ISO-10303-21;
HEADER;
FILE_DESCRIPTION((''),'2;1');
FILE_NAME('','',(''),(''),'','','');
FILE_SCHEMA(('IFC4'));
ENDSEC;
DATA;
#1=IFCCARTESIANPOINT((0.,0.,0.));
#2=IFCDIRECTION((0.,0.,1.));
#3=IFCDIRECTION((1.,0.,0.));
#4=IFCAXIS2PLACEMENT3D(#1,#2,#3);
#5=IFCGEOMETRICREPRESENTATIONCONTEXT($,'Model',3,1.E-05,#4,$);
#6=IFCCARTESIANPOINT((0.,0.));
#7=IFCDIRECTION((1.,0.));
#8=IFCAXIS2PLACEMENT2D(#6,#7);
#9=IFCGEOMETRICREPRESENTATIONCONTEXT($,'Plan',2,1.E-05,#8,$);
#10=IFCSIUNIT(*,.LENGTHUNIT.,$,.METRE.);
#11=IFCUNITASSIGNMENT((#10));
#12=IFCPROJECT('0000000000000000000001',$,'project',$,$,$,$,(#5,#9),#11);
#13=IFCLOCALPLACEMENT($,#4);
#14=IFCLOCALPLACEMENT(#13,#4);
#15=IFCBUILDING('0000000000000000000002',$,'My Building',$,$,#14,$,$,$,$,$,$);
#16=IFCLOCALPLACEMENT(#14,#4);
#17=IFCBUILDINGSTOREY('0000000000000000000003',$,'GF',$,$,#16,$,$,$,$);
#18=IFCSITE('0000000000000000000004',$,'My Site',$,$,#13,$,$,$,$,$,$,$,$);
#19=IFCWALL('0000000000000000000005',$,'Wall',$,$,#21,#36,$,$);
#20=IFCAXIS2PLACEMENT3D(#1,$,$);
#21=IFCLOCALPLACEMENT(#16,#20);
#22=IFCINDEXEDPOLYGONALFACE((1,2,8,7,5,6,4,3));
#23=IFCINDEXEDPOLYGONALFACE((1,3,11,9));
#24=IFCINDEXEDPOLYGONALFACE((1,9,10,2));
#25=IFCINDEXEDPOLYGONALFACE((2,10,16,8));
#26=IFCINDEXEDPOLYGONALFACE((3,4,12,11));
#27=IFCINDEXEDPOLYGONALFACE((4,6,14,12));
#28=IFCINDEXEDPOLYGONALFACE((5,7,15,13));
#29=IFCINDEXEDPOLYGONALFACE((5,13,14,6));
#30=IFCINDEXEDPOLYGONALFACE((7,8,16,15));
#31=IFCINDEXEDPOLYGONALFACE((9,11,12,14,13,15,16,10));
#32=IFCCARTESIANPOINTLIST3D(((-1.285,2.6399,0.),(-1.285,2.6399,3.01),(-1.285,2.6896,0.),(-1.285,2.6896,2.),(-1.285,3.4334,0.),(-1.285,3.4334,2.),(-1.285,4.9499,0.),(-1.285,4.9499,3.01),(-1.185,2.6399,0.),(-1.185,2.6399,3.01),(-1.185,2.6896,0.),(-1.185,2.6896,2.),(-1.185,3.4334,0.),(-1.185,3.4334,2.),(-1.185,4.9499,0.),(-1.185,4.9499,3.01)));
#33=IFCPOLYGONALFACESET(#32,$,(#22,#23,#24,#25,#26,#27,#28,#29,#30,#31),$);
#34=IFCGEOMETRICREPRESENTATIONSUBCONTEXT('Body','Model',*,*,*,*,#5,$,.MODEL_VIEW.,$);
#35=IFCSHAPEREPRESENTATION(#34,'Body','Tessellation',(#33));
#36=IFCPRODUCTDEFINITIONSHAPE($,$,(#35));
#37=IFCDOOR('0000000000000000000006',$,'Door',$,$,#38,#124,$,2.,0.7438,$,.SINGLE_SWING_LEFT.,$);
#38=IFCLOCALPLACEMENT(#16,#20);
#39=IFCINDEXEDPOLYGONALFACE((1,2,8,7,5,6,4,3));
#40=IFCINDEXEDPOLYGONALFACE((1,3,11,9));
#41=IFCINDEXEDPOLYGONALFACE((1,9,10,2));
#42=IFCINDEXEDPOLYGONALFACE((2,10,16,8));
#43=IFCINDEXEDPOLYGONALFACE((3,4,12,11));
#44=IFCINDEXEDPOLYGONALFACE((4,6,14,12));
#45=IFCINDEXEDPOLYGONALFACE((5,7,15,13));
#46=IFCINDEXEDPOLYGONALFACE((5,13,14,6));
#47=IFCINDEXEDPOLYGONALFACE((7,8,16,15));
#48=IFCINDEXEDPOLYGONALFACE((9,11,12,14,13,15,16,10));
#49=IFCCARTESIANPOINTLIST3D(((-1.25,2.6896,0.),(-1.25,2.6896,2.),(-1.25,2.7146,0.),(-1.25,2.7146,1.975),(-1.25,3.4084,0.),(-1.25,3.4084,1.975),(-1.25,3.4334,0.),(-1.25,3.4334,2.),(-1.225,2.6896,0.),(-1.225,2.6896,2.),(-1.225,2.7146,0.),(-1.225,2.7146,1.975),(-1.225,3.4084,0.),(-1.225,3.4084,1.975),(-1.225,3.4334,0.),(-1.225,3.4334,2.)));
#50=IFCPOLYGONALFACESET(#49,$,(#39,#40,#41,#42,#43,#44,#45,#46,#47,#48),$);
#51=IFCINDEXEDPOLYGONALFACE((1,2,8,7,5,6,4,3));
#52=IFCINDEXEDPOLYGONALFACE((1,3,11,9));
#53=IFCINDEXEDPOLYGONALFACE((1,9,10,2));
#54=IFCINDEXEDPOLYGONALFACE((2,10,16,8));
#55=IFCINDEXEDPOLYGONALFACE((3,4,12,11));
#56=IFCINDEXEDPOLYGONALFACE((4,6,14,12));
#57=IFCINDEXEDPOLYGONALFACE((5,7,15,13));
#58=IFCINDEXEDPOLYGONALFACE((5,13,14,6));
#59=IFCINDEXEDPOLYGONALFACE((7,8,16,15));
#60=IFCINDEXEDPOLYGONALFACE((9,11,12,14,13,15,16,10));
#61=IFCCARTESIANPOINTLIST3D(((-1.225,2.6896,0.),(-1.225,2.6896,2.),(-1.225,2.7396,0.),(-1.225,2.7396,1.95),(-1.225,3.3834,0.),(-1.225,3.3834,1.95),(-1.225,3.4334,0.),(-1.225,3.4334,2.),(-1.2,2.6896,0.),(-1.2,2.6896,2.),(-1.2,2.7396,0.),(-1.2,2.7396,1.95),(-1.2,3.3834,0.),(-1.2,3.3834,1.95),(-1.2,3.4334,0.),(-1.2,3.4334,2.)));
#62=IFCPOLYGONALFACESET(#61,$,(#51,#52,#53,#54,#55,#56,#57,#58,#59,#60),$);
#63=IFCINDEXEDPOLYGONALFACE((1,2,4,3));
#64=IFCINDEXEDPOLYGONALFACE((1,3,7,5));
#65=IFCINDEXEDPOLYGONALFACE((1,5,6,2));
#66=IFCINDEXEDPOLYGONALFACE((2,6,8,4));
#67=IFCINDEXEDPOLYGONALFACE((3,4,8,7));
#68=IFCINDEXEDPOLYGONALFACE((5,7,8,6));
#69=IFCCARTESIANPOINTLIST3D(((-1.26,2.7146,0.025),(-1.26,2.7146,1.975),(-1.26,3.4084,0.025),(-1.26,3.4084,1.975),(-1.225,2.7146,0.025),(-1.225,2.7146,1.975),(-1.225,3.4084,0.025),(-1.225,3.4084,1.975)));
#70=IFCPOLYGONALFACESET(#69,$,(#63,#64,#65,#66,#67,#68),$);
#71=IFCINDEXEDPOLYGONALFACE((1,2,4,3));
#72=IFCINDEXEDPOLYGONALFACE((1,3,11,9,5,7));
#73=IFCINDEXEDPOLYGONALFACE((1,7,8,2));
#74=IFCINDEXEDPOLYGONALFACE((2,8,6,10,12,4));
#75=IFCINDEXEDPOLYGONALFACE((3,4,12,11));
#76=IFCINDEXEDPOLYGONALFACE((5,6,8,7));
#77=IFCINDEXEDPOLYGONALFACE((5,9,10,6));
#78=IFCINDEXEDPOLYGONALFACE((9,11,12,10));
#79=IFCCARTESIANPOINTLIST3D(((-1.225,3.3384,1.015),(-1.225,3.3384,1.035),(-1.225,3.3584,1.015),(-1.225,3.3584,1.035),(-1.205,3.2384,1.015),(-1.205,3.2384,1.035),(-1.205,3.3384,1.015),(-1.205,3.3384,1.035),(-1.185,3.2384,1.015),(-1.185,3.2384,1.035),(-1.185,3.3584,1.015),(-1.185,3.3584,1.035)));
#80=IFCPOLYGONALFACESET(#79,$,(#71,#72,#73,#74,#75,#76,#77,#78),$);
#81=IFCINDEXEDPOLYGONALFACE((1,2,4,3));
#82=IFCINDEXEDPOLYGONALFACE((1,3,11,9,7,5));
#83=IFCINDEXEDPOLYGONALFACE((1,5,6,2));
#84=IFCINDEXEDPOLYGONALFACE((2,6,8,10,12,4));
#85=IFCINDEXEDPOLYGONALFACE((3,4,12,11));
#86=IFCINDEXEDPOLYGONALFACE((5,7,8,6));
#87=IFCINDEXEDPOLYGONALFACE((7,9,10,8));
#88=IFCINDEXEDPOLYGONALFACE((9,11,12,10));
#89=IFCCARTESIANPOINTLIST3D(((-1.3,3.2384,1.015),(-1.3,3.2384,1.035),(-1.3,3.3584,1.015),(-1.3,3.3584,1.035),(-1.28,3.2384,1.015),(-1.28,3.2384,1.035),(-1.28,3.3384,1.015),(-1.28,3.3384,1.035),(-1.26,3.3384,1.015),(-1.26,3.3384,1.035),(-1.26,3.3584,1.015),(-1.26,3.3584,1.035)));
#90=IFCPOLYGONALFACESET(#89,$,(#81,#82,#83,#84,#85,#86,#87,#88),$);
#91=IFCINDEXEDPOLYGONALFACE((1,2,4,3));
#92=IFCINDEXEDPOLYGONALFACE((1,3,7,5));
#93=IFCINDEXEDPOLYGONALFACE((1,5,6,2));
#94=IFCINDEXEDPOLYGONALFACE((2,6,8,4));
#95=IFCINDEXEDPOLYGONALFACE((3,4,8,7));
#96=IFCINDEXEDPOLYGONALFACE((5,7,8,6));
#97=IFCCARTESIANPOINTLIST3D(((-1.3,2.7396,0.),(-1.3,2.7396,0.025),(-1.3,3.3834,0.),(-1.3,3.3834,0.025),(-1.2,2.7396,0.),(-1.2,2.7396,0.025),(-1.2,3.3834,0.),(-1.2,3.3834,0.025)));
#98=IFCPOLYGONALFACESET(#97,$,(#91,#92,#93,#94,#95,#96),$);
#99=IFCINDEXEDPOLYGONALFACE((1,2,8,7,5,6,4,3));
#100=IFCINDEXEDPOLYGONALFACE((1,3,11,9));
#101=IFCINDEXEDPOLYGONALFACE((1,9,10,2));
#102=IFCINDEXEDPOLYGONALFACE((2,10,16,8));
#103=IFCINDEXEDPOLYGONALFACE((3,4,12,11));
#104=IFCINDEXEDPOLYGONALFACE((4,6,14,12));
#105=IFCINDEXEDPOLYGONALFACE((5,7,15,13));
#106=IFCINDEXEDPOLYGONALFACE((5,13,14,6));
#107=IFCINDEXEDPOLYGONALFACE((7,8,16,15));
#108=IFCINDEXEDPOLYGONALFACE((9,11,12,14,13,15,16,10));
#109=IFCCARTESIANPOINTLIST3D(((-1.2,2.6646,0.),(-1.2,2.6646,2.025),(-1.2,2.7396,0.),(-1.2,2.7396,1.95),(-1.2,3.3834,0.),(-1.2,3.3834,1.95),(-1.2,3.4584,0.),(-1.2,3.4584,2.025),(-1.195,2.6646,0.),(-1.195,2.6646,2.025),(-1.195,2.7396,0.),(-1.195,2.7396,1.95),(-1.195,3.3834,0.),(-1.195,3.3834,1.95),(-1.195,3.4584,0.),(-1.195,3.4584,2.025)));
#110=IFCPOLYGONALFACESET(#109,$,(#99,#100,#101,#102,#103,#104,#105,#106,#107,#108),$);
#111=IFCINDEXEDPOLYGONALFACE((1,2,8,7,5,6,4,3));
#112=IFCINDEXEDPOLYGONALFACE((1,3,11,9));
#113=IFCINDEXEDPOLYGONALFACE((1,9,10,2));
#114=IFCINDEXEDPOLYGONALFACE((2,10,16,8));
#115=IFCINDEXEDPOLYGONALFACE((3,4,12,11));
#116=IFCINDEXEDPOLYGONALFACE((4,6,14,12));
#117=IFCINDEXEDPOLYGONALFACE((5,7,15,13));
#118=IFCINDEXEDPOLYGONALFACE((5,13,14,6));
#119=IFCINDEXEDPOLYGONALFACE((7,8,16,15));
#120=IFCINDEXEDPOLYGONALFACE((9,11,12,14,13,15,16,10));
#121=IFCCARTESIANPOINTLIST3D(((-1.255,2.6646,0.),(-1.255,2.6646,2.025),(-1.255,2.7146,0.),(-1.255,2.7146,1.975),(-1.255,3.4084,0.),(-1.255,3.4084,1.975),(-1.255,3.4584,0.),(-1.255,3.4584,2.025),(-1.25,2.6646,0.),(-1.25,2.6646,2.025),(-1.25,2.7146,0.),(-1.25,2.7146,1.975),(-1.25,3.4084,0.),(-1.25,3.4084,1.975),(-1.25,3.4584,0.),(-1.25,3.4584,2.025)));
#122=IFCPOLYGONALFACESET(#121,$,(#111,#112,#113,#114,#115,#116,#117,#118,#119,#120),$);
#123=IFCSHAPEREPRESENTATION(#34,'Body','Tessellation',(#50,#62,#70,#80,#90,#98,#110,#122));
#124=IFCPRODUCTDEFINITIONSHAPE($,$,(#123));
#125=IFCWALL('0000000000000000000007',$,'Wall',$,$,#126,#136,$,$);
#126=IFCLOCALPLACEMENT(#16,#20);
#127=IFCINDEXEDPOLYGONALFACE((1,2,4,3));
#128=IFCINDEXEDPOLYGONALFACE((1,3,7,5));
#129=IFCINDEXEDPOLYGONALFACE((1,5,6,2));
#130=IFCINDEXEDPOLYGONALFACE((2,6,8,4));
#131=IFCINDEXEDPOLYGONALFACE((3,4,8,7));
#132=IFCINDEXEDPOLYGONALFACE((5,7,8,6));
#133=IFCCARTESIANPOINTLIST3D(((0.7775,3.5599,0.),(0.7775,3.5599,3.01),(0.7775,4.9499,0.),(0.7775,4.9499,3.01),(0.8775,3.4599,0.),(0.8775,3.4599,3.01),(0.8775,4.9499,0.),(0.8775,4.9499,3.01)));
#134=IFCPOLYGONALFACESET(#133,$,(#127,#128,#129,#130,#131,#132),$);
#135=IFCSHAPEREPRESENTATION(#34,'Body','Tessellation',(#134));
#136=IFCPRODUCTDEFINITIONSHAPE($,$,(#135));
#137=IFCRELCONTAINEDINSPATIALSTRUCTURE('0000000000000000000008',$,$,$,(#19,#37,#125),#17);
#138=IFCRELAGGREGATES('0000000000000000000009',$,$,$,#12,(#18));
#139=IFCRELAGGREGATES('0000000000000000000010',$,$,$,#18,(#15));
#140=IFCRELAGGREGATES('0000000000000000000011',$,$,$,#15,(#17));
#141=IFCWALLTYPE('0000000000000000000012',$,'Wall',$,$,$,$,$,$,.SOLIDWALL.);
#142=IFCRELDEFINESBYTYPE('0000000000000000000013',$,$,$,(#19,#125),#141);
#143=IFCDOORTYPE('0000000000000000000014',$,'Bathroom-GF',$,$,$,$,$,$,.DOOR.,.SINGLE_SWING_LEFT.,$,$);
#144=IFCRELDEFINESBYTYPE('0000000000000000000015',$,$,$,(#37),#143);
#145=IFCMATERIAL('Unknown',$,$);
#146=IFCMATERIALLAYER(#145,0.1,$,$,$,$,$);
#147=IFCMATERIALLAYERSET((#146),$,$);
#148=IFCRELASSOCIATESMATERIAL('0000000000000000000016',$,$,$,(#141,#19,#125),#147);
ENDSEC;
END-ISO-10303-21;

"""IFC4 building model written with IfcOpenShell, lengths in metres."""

from ifc_helpers import new_model, entity, si_unit, frame, origin_with_axes, origin_2d_with_axis, place, context, subcontext, project, spatial, line, indexed_curve, outline, extrude, shape, source, transform, mapped, material, layer, layer_set, layer_usage, type_object, type_shapes, element, fill, save


model = new_model("IFC4")

# Units and contexts
model_context = context("Model", 3, precision=1e-05, world=origin_with_axes())
plan_context = context("Plan", 2, precision=1e-05, world=origin_2d_with_axis())
body_context_1 = subcontext(model_context, "Body", "Model", "MODEL_VIEW")
body_context_2 = subcontext(plan_context, "Body", "Plan", "PLAN_VIEW")
ifc_project = project(units=[si_unit("LENGTHUNIT", "METRE")], contexts=[model_context, plan_context])

# Site, building, storey
site_placement = place(None, origin_with_axes())
site = spatial("IfcSite", under=ifc_project, at=site_placement, Name="My Site")
building_placement = place(site_placement, origin_with_axes())
building = spatial("IfcBuilding", under=site, at=building_placement, Name="My Building")
storey_placement = place(building_placement, origin_with_axes())
storey = spatial("IfcBuildingStorey", under=building, at=storey_placement, Name="GF")

# Shared definitions
ifc_material_1 = material(Name="Unknown")

# Shared definitions
ifc_layer_1 = layer(ifc_material_1, 0.1)
ifc_layer_set_1 = layer_set([ifc_layer_1])
wall_type = type_object("IfcWallType", Name="Wall", PredefinedType="SOLIDWALL", material=ifc_layer_set_1)

# Wall, opening, door
ifc_layer_usage_1 = layer_usage(ifc_layer_set_1, "AXIS2", "POSITIVE", 0.0)
wall_1_placement = place(storey_placement, frame((-1.185, 2.6399, 0.0), z_axis=(0.0, 0.0, 1.0), x_axis=(0.0, 1.0, 0.0)))
wall_1 = element("IfcWall", 1, at=wall_1_placement, inside=storey, type_object=wall_type, material=ifc_layer_usage_1, Name="Wall", context=body_context_1, shape_type="SweptSolid", body=[
    extrude(outline(indexed_curve([(0.0, 0.0), (0.0, 0.1), (2.31, 0.1), (2.31, 0.0)], segments=[line(1, 2, 3, 4, 1)])), origin_with_axes(), (0.0, 0.0, 1.0), 3.01),
])
shared_shape_1 = source(origin_with_axes(), body_context_1, "Body", "SweptSolid", [
    extrude(outline(indexed_curve([(0.0, 0.0), (0.7438, 0.0), (0.7438, 2.0), (0.0, 2.0)], segments=[line(1, 2, 3, 4, 1)])), frame((0.0, -0.6, 0.0), z_axis=(0.0, -1.0, 0.0), x_axis=(1.0, 0.0, 0.0)), (0.0, 0.0, -1.0), 1.2),
])
opening_1_placement = place(wall_1_placement, frame((0.0497, 0.015, 0.0), z_axis=(0.0, 0.0, 1.0), x_axis=(1.0, 0.0, 0.0)))
opening_1 = element("IfcOpeningElement", 2, at=opening_1_placement, cuts=wall_1, PredefinedType="OPENING", context=body_context_1, shape_type="MappedRepresentation", body=[
    mapped(shared_shape_1, transform((0.0, 0.0, 0.0), x_axis=(1.0, 0.0, 0.0), y_axis=(0.0, 1.0, 0.0), z_axis=(0.0, 0.0, 1.0), scale=1.0)),
])
door_type_1 = type_object("IfcDoorType", Name="Bathroom-GF", OperationType="SINGLE_SWING_LEFT", PredefinedType="DOOR")
shared_shape_2 = source(origin_with_axes(), body_context_1, "Body", "SweptSolid", [
    extrude(outline(indexed_curve([(0.0, 0.0), (0.0, 2.0), (0.7438, 2.0), (0.7438, 0.0), (0.7188, 0.0), (0.7188, 1.975), (0.025, 1.975), (0.025, 0.0)], segments=[line(1, 2, 3, 4, 5, 6, 7, 8, 1)])), frame((0.0, 0.025, 0.0), z_axis=(0.0, -1.0, 0.0), x_axis=(1.0, 0.0, 0.0)), (0.0, 0.0, -1.0), 0.025),
    extrude(outline(indexed_curve([(0.0, 0.0), (0.0, 2.0), (0.7438, 2.0), (0.7438, 0.0), (0.6938, 0.0), (0.6938, 1.95), (0.05, 1.95), (0.05, 0.0)], segments=[line(1, 2, 3, 4, 5, 6, 7, 8, 1)])), frame((0.0, 0.0, 0.0), z_axis=(0.0, -1.0, 0.0), x_axis=(1.0, 0.0, 0.0)), (0.0, 0.0, -1.0), 0.025),
    extrude(outline(indexed_curve([(0.0, 0.0), (0.6938, 0.0), (0.6938, 0.035), (0.0, 0.035)], segments=[line(1, 2, 3, 4, 1)])), frame((0.025, 0.025, 0.025), z_axis=(0.0, 0.0, 1.0), x_axis=(1.0, 0.0, 0.0)), (0.0, 0.0, 1.0), 1.95),
    extrude(outline(indexed_curve([(0.0, 0.0), (0.0, -0.04), (-0.12, -0.04), (-0.12, -0.02), (-0.02, -0.02), (-0.02, 0.0)], segments=[line(1, 2, 3, 4, 5, 6, 1)])), frame((0.6688, 0.025, 1.015), z_axis=(0.0, 0.0, 1.0), x_axis=(1.0, 0.0, 0.0)), (0.0, 0.0, 1.0), 0.02),
    extrude(outline(indexed_curve([(0.0, 0.0), (0.0, 0.04), (-0.12, 0.04), (-0.12, 0.02), (-0.02, 0.02), (-0.02, 0.0)], segments=[line(1, 2, 3, 4, 5, 6, 1)])), frame((0.6688, 0.06, 1.015), z_axis=(0.0, 0.0, 1.0), x_axis=(1.0, 0.0, 0.0)), (0.0, 0.0, 1.0), 0.02),
    extrude(outline(indexed_curve([(0.0, 0.0), (0.6438, 0.0), (0.6438, 0.1), (0.0, 0.1)], segments=[line(1, 2, 3, 4, 1)])), frame((0.05, 0.0, 0.0), z_axis=(0.0, 0.0, 1.0), x_axis=(1.0, 0.0, 0.0)), (0.0, 0.0, 1.0), 0.025),
    extrude(outline(indexed_curve([(0.0, 0.0), (0.0, 2.025), (0.7938, 2.025), (0.7938, 0.0), (0.7188, 0.0), (0.7188, 1.95), (0.075, 1.95), (0.075, 0.0)], segments=[line(1, 2, 3, 4, 5, 6, 7, 8, 1)])), frame((-0.025, -0.005, 0.0), z_axis=(0.0, -1.0, 0.0), x_axis=(1.0, 0.0, 0.0)), (0.0, 0.0, -1.0), 0.005),
    extrude(outline(indexed_curve([(0.0, 0.0), (0.0, 2.025), (0.7938, 2.025), (0.7938, 0.0), (0.7438, 0.0), (0.7438, 1.975), (0.05, 1.975), (0.05, 0.0)], segments=[line(1, 2, 3, 4, 5, 6, 7, 8, 1)])), frame((-0.025, 0.05, 0.0), z_axis=(0.0, -1.0, 0.0), x_axis=(1.0, 0.0, 0.0)), (0.0, 0.0, -1.0), 0.005),
])
shared_shape_3 = source(origin_with_axes(), body_context_2, "Body", "Curve2D", [
    entity("IfcIndexedPolyCurve", entity("IfcCartesianPointList2D", [[0.0, 0.0], [0.0, 0.05], [0.025, 0.05], [0.025, 0.025], [0.05, 0.025], [0.05, 0.0]]), [entity("IfcLineIndex", [1, 2, 3, 4, 5, 6, 1])]),
    entity("IfcIndexedPolyCurve", entity("IfcCartesianPointList2D", [[0.7438, 0.0], [0.7438, 0.05], [0.7188, 0.05], [0.7188, 0.025], [0.6938, 0.025], [0.6938, 0.0]]), [entity("IfcLineIndex", [1, 2, 3, 4, 5, 6, 1])]),
    entity("IfcTrimmedCurve", entity("IfcEllipse", entity("IfcAxis2Placement2D", entity("IfcCartesianPoint", [0.06, 0.05]), entity("IfcDirection", [1.0, 0.0])), 0.6588, 0.6938), [entity("IfcCartesianPoint", [0.7188, 0.05])], [entity("IfcCartesianPoint", [0.06, 0.7438])], True, "CARTESIAN"),
    entity("IfcIndexedPolyCurve", entity("IfcCartesianPointList2D", [[0.025, 0.05], [0.06, 0.05], [0.06, 0.7438], [0.025, 0.7438]]), [entity("IfcLineIndex", [1, 2, 3, 4, 1])]),
])
type_shapes(door_type_1, [shared_shape_2, shared_shape_3])
door_1_placement = place(opening_1_placement, frame((0.0, 0.0, 0.0), z_axis=(0.0, 0.0, 1.0), x_axis=(1.0, 0.0, 0.0)))
door_1 = element("IfcDoor", 3, at=door_1_placement, inside=storey, type_object=door_type_1, Name="Door", OperationType="SINGLE_SWING_LEFT", OverallHeight=2.0, OverallWidth=0.7438, shapes=[
    shape(body_context_1, "Body", "MappedRepresentation", [mapped(shared_shape_2, transform((0.0, 0.0, 0.0), x_axis=(1.0, 0.0, 0.0), y_axis=(0.0, 1.0, 0.0), z_axis=(0.0, 0.0, 1.0), scale=1.0))]),
    shape(body_context_2, "Body", "MappedRepresentation", [mapped(shared_shape_3, transform((0.0, 0.0, 0.0), x_axis=(1.0, 0.0, 0.0), y_axis=(0.0, 1.0, 0.0), z_axis=(0.0, 0.0, 1.0), scale=1.0))]),
])
fill(opening_1, door_1)

# Wall
ifc_layer_usage_2 = layer_usage(ifc_layer_set_1, "AXIS2", "POSITIVE", 0.0)
wall_2_placement = place(storey_placement, frame((0.7775, 4.9499, 0.0), z_axis=(0.0, 0.0, 1.0), x_axis=(0.0, -1.0, 0.0)))
element("IfcWall", 4, at=wall_2_placement, inside=storey, type_object=wall_type, material=ifc_layer_usage_2, Name="Wall", context=body_context_1, shape_type="SweptSolid", body=[
    extrude(outline(indexed_curve([(0.0, 0.0), (0.0, 0.1), (1.49, 0.1), (1.39, 0.0)], segments=[line(1, 2, 3, 4, 1)])), origin_with_axes(), (0.0, 0.0, 1.0), 3.01),
])

save(model, "model.ifc")
